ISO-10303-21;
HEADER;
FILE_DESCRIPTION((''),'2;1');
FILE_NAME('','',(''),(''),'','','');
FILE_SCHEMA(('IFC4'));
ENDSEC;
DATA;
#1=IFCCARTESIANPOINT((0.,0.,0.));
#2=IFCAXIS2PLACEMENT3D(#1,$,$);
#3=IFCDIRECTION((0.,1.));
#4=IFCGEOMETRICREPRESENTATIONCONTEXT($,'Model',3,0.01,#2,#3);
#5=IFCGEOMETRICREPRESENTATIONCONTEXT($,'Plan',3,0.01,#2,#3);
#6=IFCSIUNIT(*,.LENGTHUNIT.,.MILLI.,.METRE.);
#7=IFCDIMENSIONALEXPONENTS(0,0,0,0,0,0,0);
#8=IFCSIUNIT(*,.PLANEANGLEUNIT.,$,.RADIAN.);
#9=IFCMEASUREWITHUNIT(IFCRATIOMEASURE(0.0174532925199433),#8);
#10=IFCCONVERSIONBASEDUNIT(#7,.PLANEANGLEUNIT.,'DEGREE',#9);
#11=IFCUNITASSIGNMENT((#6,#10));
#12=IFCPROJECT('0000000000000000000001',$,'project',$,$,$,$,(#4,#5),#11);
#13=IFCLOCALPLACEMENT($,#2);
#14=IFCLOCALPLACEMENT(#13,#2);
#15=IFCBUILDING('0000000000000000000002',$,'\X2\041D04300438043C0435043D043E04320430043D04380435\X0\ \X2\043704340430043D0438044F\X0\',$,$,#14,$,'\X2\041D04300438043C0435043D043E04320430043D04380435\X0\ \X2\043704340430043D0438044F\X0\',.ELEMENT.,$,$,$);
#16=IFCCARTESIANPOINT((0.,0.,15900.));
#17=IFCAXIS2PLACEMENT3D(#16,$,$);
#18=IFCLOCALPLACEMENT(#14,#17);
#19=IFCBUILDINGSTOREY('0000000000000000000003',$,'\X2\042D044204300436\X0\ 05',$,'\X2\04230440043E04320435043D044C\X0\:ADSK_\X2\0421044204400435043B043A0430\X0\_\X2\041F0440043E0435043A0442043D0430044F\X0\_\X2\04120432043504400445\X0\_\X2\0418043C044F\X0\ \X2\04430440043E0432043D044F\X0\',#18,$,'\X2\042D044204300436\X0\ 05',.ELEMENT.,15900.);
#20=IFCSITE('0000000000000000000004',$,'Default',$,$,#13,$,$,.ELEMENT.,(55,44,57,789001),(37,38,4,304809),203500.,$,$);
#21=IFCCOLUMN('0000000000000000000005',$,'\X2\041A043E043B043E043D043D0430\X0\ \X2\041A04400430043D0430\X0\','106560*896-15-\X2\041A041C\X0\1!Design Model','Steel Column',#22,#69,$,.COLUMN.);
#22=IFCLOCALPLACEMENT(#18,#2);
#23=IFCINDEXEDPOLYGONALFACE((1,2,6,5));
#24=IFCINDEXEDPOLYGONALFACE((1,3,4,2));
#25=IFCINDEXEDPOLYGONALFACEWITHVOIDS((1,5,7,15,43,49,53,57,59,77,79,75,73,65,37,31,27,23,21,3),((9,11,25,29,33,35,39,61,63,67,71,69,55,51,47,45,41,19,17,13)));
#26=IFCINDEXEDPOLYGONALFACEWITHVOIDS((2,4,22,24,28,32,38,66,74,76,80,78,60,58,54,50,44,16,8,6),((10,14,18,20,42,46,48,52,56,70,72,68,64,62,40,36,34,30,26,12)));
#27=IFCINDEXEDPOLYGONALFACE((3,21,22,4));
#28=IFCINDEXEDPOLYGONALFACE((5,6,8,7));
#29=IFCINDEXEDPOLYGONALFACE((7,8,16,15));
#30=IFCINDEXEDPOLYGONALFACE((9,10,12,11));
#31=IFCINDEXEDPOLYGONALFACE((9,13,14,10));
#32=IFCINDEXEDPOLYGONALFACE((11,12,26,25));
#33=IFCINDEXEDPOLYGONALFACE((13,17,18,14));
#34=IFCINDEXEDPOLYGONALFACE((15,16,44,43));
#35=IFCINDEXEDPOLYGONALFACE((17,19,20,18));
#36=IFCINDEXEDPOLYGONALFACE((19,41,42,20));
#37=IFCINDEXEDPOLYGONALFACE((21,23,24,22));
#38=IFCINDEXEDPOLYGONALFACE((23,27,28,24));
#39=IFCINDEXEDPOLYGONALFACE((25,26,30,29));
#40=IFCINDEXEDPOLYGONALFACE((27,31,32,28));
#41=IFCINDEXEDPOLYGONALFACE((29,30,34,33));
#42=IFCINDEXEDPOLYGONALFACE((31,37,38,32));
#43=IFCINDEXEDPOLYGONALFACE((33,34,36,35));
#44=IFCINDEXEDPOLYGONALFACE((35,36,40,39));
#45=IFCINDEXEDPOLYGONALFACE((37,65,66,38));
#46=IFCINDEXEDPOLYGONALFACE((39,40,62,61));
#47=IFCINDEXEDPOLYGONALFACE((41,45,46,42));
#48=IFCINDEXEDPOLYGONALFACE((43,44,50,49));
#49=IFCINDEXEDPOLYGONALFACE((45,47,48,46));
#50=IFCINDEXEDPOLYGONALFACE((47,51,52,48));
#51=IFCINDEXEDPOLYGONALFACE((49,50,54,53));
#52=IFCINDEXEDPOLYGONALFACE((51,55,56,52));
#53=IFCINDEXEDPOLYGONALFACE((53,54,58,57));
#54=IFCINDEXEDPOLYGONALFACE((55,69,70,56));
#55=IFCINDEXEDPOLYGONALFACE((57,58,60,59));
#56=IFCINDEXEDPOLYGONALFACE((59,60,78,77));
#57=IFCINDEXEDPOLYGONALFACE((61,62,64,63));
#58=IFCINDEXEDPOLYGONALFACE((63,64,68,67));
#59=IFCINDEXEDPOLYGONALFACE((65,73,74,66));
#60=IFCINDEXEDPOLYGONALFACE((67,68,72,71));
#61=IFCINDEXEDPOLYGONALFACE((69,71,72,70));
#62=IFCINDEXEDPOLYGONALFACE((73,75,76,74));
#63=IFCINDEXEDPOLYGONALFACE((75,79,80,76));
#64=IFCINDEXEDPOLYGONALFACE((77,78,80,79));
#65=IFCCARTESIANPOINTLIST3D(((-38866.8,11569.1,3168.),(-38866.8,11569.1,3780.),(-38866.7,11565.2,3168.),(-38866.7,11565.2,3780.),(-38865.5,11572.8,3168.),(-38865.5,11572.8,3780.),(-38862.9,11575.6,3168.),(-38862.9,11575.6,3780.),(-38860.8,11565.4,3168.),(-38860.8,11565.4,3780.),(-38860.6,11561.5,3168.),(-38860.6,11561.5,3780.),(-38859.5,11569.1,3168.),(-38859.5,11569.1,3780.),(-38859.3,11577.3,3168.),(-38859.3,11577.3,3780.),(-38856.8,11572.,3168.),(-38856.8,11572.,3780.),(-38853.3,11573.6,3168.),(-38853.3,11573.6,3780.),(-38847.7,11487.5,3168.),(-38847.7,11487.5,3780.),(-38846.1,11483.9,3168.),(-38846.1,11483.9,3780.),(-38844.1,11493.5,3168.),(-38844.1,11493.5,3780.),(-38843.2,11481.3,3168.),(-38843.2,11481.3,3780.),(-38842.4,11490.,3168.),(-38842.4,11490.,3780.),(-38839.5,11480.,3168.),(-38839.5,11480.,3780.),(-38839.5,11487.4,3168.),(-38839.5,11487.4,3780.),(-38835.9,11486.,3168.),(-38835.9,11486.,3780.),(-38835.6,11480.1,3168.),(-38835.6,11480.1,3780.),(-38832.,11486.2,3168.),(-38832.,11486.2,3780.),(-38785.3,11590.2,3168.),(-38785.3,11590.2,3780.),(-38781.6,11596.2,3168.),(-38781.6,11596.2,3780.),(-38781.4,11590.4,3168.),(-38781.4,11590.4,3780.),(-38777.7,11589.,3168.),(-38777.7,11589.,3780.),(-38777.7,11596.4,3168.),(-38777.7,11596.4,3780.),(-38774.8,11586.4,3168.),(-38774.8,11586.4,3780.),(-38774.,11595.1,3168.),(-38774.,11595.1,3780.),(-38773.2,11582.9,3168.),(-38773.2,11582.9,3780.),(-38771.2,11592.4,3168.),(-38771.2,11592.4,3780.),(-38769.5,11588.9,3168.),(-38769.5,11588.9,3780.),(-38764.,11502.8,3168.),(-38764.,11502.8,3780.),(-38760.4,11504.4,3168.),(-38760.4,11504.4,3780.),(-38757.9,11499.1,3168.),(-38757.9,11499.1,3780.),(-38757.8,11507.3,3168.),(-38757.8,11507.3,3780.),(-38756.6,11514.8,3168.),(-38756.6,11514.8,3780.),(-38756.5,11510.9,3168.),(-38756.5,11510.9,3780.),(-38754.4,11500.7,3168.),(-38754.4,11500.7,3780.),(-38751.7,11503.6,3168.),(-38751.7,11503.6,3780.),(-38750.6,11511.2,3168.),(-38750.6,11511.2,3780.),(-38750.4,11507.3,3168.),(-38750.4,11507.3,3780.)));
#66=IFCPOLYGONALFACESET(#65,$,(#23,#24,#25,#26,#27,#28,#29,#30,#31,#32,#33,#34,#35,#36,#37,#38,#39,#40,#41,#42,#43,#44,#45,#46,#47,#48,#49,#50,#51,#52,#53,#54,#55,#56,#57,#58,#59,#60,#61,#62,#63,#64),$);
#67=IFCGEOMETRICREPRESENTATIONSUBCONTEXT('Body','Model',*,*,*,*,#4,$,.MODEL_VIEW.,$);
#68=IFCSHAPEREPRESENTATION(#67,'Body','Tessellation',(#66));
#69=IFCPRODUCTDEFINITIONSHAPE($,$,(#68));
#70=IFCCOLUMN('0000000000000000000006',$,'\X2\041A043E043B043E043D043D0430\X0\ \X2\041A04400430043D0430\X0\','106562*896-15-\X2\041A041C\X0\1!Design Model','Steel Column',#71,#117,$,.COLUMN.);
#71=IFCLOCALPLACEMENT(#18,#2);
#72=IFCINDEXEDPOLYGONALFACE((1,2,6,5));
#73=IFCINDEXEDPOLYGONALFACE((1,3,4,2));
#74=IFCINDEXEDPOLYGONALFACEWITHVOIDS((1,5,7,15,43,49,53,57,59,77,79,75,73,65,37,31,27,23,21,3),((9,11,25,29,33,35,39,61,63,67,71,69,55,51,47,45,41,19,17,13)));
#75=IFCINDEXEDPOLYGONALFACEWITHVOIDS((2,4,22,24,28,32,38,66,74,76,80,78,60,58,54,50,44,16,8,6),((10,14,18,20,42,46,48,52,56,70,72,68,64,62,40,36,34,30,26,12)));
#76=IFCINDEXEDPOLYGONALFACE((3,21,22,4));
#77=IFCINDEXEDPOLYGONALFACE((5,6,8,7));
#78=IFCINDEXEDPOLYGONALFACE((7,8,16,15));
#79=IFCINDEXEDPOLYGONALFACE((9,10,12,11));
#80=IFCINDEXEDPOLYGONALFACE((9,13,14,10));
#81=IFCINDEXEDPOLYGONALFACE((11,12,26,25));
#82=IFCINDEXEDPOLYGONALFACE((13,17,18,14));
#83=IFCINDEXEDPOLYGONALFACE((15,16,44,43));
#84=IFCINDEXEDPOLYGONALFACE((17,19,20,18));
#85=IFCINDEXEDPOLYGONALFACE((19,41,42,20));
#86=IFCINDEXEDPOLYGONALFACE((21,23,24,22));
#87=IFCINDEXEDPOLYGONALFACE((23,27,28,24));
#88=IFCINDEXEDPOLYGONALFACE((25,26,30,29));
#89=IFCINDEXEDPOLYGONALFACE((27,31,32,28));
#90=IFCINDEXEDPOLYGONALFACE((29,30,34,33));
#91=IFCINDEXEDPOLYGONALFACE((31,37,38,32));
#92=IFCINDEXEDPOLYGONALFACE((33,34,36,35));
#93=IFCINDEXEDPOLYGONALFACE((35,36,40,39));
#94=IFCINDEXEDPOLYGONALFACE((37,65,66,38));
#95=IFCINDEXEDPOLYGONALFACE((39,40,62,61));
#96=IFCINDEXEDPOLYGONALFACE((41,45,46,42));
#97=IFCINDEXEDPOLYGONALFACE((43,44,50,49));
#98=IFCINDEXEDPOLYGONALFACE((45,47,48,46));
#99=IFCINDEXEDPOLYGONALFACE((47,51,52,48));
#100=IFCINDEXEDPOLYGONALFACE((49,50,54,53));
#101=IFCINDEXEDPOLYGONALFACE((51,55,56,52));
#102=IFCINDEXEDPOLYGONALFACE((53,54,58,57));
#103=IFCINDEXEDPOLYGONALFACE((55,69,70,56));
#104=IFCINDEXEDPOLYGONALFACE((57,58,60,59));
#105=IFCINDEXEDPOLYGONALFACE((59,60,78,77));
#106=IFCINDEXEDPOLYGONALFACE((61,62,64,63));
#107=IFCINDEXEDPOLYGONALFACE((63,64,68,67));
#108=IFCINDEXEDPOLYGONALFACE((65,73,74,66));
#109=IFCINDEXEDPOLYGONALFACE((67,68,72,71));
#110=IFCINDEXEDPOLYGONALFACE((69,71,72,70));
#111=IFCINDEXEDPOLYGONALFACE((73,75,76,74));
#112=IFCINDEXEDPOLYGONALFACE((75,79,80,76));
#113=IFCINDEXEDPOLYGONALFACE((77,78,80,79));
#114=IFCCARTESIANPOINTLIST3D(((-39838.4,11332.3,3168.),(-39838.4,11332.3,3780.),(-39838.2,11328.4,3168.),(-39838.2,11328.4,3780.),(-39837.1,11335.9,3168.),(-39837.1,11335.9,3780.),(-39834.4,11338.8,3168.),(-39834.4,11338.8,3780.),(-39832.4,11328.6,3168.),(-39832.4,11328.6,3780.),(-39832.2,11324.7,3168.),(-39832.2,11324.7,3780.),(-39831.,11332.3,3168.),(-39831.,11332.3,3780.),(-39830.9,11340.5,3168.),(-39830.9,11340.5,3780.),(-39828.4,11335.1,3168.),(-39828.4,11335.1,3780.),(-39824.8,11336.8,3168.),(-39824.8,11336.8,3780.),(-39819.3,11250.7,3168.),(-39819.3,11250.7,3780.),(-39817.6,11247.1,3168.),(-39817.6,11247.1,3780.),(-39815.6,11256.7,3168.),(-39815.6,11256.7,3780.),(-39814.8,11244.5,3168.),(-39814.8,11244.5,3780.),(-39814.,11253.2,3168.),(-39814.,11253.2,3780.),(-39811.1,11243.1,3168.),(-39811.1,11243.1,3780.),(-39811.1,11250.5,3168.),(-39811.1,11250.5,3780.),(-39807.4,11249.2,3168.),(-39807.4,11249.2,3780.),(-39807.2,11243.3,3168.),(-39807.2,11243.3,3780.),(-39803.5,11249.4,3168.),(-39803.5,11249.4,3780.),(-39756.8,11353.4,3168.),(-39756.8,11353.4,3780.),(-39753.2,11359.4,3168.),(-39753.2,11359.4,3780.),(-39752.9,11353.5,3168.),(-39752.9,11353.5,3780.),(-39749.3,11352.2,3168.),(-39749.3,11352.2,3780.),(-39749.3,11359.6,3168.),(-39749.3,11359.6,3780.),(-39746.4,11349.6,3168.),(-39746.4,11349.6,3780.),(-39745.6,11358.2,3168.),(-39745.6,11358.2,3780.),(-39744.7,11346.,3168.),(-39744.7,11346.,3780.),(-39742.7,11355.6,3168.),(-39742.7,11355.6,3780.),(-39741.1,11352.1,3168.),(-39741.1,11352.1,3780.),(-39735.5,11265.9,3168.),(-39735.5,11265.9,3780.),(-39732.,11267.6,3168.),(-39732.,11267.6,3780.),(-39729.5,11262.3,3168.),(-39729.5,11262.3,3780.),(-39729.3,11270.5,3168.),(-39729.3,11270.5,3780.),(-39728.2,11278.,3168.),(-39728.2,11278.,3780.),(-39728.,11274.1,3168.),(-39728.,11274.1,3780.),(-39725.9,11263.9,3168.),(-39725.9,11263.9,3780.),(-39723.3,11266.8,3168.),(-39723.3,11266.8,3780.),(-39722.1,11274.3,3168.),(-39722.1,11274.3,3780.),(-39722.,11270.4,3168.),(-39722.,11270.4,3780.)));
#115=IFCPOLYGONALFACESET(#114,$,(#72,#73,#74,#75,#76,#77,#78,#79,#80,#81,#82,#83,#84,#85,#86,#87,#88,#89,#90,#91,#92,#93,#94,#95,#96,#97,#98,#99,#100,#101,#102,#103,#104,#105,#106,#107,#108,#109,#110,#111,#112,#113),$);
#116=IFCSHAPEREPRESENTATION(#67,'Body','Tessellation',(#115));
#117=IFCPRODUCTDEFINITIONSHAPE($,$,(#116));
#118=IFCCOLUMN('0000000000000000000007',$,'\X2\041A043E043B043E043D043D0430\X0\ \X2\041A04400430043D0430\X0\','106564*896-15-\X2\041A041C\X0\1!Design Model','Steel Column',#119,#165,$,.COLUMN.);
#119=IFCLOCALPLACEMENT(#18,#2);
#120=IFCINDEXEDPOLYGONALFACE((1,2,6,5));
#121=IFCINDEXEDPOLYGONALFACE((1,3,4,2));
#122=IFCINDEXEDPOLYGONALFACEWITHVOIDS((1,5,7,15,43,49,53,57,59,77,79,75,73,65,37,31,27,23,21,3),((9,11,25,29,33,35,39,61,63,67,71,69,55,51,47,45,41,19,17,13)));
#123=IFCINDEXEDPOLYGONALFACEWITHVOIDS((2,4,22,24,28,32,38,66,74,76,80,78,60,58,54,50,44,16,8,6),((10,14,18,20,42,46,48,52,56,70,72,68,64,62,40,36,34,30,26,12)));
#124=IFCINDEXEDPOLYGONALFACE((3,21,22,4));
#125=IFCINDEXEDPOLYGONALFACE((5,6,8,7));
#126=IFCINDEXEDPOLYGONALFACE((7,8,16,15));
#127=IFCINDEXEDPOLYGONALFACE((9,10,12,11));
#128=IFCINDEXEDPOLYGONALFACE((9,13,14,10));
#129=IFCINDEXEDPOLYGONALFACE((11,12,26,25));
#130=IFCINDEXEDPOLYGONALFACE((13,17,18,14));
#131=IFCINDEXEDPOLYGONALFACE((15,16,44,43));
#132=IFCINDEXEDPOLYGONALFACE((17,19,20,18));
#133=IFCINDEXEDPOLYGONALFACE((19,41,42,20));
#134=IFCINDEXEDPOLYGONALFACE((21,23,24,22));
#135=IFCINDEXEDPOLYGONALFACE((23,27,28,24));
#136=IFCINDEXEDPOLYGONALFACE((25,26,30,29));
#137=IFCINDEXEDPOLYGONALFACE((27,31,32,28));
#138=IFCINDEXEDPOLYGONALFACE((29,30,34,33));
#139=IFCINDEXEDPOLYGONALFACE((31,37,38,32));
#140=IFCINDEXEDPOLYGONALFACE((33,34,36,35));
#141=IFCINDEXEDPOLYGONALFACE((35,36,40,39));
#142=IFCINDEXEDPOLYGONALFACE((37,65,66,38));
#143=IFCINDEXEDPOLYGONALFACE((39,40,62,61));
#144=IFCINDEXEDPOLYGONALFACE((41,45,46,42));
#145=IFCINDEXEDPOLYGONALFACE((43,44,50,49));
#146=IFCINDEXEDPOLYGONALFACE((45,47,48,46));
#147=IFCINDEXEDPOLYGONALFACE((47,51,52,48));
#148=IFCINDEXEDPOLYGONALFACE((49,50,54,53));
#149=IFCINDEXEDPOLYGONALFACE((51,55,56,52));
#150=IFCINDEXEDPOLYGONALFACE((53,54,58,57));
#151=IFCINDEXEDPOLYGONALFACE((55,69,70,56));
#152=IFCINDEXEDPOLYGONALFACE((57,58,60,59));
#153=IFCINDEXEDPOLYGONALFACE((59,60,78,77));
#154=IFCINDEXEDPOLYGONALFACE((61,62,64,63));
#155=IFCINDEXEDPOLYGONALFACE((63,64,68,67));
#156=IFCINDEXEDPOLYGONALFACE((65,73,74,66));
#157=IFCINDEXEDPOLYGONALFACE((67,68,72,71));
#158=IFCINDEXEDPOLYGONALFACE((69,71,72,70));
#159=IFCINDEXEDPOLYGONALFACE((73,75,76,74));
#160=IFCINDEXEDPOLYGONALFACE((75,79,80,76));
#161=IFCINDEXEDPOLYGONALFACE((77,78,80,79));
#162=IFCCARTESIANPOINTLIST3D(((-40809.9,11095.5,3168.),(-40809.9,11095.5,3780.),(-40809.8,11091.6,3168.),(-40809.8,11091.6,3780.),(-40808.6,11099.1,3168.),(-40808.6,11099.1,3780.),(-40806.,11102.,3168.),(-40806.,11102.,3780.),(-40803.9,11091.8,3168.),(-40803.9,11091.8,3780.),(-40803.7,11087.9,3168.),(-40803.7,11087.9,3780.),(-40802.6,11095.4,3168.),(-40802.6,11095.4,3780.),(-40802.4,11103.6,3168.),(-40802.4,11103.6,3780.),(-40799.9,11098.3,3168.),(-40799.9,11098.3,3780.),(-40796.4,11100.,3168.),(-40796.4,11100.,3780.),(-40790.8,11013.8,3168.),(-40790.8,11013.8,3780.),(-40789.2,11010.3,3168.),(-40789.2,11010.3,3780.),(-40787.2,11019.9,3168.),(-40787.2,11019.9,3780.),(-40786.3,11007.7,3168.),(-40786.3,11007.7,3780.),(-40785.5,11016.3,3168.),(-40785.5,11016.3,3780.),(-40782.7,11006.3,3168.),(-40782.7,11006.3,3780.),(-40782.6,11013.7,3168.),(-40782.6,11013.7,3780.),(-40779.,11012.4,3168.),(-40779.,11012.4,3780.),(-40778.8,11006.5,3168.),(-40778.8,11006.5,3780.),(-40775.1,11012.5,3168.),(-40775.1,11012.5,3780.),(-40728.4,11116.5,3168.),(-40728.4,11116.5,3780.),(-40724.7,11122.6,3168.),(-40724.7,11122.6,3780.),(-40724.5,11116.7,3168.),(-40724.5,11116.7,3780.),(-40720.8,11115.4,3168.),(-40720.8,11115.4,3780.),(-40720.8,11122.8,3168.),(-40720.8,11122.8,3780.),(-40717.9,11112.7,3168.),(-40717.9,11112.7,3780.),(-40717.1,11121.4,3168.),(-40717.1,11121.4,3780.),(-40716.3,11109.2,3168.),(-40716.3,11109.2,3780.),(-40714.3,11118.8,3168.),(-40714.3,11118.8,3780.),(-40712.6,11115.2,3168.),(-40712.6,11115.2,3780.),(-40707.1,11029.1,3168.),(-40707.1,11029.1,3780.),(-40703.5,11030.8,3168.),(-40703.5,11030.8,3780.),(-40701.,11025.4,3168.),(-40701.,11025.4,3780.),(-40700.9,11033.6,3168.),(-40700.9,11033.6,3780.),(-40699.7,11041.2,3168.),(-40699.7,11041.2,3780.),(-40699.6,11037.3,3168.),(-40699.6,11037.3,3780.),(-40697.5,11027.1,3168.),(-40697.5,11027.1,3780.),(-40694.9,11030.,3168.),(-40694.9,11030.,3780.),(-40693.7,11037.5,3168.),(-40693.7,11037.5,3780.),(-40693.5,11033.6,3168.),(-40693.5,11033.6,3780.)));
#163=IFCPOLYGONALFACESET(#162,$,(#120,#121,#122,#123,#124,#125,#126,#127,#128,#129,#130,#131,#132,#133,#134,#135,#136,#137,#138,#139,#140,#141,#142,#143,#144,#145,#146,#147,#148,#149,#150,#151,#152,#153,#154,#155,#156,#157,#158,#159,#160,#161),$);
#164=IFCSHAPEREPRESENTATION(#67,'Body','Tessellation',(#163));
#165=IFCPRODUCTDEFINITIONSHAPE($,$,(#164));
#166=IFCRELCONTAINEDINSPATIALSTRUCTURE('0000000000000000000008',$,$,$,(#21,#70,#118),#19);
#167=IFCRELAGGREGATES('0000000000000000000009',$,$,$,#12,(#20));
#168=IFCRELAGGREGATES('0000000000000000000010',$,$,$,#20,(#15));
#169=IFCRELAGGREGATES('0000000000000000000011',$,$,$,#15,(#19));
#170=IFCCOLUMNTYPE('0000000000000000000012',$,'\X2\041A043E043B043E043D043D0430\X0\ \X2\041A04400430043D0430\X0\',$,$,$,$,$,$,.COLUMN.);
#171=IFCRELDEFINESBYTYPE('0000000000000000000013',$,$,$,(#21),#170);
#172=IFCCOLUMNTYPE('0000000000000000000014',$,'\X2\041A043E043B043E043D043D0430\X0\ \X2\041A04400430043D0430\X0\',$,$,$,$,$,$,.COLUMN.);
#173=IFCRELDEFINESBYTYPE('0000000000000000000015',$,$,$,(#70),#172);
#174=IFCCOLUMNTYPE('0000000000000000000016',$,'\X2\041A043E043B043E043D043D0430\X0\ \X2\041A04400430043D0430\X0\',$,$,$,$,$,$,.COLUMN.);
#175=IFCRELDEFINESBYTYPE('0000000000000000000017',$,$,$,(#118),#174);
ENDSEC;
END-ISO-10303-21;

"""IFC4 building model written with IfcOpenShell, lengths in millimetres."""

from ifc_helpers import new_model, entity, si_unit, converted_unit, direction, frame, origin, place, context, subcontext, project, spatial, indexed_curve, outline, extrude, type_object, element, save


model = new_model("IFC4")

# Units and contexts
model_context = context("Model", 3, precision=0.01, world=origin(), true_north=direction((0.0, 1.0)))
plan_context = context("Plan", 3, precision=0.01, world=origin(), true_north=direction((0.0, 1.0)))
body_context = subcontext(model_context, "Body", "Model", "MODEL_VIEW")
ifc_project = project(units=[si_unit("LENGTHUNIT", "METRE", prefix="MILLI"), converted_unit("PLANEANGLEUNIT", "DEGREE", entity("IfcRatioMeasure", 0.0174532925199433), si_unit("PLANEANGLEUNIT", "RADIAN"), dimensions=[0, 0, 0, 0, 0, 0, 0])], contexts=[model_context, plan_context])

# Site, building, storey
site_placement = place(None, origin())
site = spatial("IfcSite", under=ifc_project, at=site_placement, Name="Default", CompositionType="ELEMENT", RefLatitude=(55, 44, 57, 789001), RefLongitude=(37, 38, 4, 304809), RefElevation=203500.0)
building_placement = place(site_placement, origin())
building = spatial("IfcBuilding", under=site, at=building_placement, Name="Наименование здания", LongName="Наименование здания", CompositionType="ELEMENT")
storey_placement = place(building_placement, frame((0.0, 0.0, 15900.0)))
storey = spatial("IfcBuildingStorey", under=building, at=storey_placement, Name="Этаж 05", ObjectType="Уровень:ADSK_Стрелка_Проектная_Вверх_Имя уровня", LongName="Этаж 05", CompositionType="ELEMENT", Elevation=15900.0)

# Columns
column_type_1 = type_object("IfcColumnType", Name="Колонна Крана", PredefinedType="COLUMN")
column_1_placement = place(storey_placement, origin())
element("IfcColumn", 1, at=column_1_placement, inside=storey, type_object=column_type_1, Name="Колонна Крана", Description="106560*896-15-КМ1!Design Model", ObjectType="Steel Column", PredefinedType="COLUMN", context=body_context, shape_type="SweptSolid", body=[
    extrude(outline(indexed_curve([(29.5, -56.8), (33.4, -56.8), (37.0, -55.3), (39.7, -52.6), (41.2, -49.0), (56.8, 29.5), (56.8, 33.4), (55.3, 37.0), (52.6, 39.7), (49.0, 41.2), (-29.5, 56.8), (-33.4, 56.8), (-37.0, 55.3), (-39.7, 52.6), (-41.2, 49.0), (-56.8, -29.5), (-56.8, -33.4), (-55.3, -37.0), (-52.6, -39.7), (-49.0, -41.2), (29.5, -56.8)], self_intersect=False), holes=[indexed_curve([(-43.1, -37.3), (-46.7, -35.8), (-49.5, -33.1), (-51.0, -29.5), (-51.0, -25.5), (-37.3, 43.1), (-35.8, 46.7), (-33.1, 49.5), (-29.5, 51.0), (-25.5, 51.0), (43.1, 37.3), (46.7, 35.8), (49.5, 33.1), (51.0, 29.5), (51.0, 25.5), (37.3, -43.1), (35.8, -46.7), (33.1, -49.5), (29.5, -51.0), (25.5, -51.0), (-43.1, -37.3)], self_intersect=False)]), frame((-38808.6, 11538.2, 3168.0), z_axis=(0.0, 0.0, 1.0), x_axis=(0.906681, 0.421816, 0.0)), (0.0, 0.0, 1.0), 612.0),
])
column_type_2 = type_object("IfcColumnType", Name="Колонна Крана", PredefinedType="COLUMN")
column_2_placement = place(storey_placement, origin())
element("IfcColumn", 2, at=column_2_placement, inside=storey, type_object=column_type_2, Name="Колонна Крана", Description="106562*896-15-КМ1!Design Model", ObjectType="Steel Column", PredefinedType="COLUMN", context=body_context, shape_type="SweptSolid", body=[
    extrude(outline(indexed_curve([(29.5, -56.8), (33.4, -56.8), (37.0, -55.3), (39.7, -52.6), (41.2, -49.0), (56.8, 29.5), (56.8, 33.4), (55.3, 37.0), (52.6, 39.7), (49.0, 41.2), (-29.5, 56.8), (-33.4, 56.8), (-37.0, 55.3), (-39.7, 52.6), (-41.2, 49.0), (-56.8, -29.5), (-56.8, -33.4), (-55.3, -37.0), (-52.6, -39.7), (-49.0, -41.2), (29.5, -56.8)], self_intersect=False), holes=[indexed_curve([(-43.1, -37.3), (-46.7, -35.8), (-49.5, -33.1), (-51.0, -29.5), (-51.0, -25.5), (-37.3, 43.1), (-35.8, 46.7), (-33.1, 49.5), (-29.5, 51.0), (-25.5, 51.0), (43.1, 37.3), (46.7, 35.8), (49.5, 33.1), (51.0, 29.5), (51.0, 25.5), (37.3, -43.1), (35.8, -46.7), (33.1, -49.5), (29.5, -51.0), (25.5, -51.0), (-43.1, -37.3)], self_intersect=False)]), frame((-39780.2, 11301.4, 3168.0), z_axis=(0.0, 0.0, 1.0), x_axis=(0.906681, 0.421816, 0.0)), (0.0, 0.0, 1.0), 612.0),
])
column_type_3 = type_object("IfcColumnType", Name="Колонна Крана", PredefinedType="COLUMN")
column_3_placement = place(storey_placement, origin())
element("IfcColumn", 3, at=column_3_placement, inside=storey, type_object=column_type_3, Name="Колонна Крана", Description="106564*896-15-КМ1!Design Model", ObjectType="Steel Column", PredefinedType="COLUMN", context=body_context, shape_type="SweptSolid", body=[
    extrude(outline(indexed_curve([(29.5, -56.8), (33.4, -56.8), (37.0, -55.3), (39.7, -52.6), (41.2, -49.0), (56.8, 29.5), (56.8, 33.4), (55.3, 37.0), (52.6, 39.7), (49.0, 41.2), (-29.5, 56.8), (-33.4, 56.8), (-37.0, 55.3), (-39.7, 52.6), (-41.2, 49.0), (-56.8, -29.5), (-56.8, -33.4), (-55.3, -37.0), (-52.6, -39.7), (-49.0, -41.2), (29.5, -56.8)], self_intersect=False), holes=[indexed_curve([(-43.1, -37.3), (-46.7, -35.8), (-49.5, -33.1), (-51.0, -29.5), (-51.0, -25.5), (-37.3, 43.1), (-35.8, 46.7), (-33.1, 49.5), (-29.5, 51.0), (-25.5, 51.0), (43.1, 37.3), (46.7, 35.8), (49.5, 33.1), (51.0, 29.5), (51.0, 25.5), (37.3, -43.1), (35.8, -46.7), (33.1, -49.5), (29.5, -51.0), (25.5, -51.0), (-43.1, -37.3)], self_intersect=False)]), frame((-40751.7, 11064.5, 3168.0), z_axis=(0.0, 0.0, 1.0), x_axis=(0.906681, 0.421816, 0.0)), (0.0, 0.0, 1.0), 612.0),
])

save(model, "model.ifc")
